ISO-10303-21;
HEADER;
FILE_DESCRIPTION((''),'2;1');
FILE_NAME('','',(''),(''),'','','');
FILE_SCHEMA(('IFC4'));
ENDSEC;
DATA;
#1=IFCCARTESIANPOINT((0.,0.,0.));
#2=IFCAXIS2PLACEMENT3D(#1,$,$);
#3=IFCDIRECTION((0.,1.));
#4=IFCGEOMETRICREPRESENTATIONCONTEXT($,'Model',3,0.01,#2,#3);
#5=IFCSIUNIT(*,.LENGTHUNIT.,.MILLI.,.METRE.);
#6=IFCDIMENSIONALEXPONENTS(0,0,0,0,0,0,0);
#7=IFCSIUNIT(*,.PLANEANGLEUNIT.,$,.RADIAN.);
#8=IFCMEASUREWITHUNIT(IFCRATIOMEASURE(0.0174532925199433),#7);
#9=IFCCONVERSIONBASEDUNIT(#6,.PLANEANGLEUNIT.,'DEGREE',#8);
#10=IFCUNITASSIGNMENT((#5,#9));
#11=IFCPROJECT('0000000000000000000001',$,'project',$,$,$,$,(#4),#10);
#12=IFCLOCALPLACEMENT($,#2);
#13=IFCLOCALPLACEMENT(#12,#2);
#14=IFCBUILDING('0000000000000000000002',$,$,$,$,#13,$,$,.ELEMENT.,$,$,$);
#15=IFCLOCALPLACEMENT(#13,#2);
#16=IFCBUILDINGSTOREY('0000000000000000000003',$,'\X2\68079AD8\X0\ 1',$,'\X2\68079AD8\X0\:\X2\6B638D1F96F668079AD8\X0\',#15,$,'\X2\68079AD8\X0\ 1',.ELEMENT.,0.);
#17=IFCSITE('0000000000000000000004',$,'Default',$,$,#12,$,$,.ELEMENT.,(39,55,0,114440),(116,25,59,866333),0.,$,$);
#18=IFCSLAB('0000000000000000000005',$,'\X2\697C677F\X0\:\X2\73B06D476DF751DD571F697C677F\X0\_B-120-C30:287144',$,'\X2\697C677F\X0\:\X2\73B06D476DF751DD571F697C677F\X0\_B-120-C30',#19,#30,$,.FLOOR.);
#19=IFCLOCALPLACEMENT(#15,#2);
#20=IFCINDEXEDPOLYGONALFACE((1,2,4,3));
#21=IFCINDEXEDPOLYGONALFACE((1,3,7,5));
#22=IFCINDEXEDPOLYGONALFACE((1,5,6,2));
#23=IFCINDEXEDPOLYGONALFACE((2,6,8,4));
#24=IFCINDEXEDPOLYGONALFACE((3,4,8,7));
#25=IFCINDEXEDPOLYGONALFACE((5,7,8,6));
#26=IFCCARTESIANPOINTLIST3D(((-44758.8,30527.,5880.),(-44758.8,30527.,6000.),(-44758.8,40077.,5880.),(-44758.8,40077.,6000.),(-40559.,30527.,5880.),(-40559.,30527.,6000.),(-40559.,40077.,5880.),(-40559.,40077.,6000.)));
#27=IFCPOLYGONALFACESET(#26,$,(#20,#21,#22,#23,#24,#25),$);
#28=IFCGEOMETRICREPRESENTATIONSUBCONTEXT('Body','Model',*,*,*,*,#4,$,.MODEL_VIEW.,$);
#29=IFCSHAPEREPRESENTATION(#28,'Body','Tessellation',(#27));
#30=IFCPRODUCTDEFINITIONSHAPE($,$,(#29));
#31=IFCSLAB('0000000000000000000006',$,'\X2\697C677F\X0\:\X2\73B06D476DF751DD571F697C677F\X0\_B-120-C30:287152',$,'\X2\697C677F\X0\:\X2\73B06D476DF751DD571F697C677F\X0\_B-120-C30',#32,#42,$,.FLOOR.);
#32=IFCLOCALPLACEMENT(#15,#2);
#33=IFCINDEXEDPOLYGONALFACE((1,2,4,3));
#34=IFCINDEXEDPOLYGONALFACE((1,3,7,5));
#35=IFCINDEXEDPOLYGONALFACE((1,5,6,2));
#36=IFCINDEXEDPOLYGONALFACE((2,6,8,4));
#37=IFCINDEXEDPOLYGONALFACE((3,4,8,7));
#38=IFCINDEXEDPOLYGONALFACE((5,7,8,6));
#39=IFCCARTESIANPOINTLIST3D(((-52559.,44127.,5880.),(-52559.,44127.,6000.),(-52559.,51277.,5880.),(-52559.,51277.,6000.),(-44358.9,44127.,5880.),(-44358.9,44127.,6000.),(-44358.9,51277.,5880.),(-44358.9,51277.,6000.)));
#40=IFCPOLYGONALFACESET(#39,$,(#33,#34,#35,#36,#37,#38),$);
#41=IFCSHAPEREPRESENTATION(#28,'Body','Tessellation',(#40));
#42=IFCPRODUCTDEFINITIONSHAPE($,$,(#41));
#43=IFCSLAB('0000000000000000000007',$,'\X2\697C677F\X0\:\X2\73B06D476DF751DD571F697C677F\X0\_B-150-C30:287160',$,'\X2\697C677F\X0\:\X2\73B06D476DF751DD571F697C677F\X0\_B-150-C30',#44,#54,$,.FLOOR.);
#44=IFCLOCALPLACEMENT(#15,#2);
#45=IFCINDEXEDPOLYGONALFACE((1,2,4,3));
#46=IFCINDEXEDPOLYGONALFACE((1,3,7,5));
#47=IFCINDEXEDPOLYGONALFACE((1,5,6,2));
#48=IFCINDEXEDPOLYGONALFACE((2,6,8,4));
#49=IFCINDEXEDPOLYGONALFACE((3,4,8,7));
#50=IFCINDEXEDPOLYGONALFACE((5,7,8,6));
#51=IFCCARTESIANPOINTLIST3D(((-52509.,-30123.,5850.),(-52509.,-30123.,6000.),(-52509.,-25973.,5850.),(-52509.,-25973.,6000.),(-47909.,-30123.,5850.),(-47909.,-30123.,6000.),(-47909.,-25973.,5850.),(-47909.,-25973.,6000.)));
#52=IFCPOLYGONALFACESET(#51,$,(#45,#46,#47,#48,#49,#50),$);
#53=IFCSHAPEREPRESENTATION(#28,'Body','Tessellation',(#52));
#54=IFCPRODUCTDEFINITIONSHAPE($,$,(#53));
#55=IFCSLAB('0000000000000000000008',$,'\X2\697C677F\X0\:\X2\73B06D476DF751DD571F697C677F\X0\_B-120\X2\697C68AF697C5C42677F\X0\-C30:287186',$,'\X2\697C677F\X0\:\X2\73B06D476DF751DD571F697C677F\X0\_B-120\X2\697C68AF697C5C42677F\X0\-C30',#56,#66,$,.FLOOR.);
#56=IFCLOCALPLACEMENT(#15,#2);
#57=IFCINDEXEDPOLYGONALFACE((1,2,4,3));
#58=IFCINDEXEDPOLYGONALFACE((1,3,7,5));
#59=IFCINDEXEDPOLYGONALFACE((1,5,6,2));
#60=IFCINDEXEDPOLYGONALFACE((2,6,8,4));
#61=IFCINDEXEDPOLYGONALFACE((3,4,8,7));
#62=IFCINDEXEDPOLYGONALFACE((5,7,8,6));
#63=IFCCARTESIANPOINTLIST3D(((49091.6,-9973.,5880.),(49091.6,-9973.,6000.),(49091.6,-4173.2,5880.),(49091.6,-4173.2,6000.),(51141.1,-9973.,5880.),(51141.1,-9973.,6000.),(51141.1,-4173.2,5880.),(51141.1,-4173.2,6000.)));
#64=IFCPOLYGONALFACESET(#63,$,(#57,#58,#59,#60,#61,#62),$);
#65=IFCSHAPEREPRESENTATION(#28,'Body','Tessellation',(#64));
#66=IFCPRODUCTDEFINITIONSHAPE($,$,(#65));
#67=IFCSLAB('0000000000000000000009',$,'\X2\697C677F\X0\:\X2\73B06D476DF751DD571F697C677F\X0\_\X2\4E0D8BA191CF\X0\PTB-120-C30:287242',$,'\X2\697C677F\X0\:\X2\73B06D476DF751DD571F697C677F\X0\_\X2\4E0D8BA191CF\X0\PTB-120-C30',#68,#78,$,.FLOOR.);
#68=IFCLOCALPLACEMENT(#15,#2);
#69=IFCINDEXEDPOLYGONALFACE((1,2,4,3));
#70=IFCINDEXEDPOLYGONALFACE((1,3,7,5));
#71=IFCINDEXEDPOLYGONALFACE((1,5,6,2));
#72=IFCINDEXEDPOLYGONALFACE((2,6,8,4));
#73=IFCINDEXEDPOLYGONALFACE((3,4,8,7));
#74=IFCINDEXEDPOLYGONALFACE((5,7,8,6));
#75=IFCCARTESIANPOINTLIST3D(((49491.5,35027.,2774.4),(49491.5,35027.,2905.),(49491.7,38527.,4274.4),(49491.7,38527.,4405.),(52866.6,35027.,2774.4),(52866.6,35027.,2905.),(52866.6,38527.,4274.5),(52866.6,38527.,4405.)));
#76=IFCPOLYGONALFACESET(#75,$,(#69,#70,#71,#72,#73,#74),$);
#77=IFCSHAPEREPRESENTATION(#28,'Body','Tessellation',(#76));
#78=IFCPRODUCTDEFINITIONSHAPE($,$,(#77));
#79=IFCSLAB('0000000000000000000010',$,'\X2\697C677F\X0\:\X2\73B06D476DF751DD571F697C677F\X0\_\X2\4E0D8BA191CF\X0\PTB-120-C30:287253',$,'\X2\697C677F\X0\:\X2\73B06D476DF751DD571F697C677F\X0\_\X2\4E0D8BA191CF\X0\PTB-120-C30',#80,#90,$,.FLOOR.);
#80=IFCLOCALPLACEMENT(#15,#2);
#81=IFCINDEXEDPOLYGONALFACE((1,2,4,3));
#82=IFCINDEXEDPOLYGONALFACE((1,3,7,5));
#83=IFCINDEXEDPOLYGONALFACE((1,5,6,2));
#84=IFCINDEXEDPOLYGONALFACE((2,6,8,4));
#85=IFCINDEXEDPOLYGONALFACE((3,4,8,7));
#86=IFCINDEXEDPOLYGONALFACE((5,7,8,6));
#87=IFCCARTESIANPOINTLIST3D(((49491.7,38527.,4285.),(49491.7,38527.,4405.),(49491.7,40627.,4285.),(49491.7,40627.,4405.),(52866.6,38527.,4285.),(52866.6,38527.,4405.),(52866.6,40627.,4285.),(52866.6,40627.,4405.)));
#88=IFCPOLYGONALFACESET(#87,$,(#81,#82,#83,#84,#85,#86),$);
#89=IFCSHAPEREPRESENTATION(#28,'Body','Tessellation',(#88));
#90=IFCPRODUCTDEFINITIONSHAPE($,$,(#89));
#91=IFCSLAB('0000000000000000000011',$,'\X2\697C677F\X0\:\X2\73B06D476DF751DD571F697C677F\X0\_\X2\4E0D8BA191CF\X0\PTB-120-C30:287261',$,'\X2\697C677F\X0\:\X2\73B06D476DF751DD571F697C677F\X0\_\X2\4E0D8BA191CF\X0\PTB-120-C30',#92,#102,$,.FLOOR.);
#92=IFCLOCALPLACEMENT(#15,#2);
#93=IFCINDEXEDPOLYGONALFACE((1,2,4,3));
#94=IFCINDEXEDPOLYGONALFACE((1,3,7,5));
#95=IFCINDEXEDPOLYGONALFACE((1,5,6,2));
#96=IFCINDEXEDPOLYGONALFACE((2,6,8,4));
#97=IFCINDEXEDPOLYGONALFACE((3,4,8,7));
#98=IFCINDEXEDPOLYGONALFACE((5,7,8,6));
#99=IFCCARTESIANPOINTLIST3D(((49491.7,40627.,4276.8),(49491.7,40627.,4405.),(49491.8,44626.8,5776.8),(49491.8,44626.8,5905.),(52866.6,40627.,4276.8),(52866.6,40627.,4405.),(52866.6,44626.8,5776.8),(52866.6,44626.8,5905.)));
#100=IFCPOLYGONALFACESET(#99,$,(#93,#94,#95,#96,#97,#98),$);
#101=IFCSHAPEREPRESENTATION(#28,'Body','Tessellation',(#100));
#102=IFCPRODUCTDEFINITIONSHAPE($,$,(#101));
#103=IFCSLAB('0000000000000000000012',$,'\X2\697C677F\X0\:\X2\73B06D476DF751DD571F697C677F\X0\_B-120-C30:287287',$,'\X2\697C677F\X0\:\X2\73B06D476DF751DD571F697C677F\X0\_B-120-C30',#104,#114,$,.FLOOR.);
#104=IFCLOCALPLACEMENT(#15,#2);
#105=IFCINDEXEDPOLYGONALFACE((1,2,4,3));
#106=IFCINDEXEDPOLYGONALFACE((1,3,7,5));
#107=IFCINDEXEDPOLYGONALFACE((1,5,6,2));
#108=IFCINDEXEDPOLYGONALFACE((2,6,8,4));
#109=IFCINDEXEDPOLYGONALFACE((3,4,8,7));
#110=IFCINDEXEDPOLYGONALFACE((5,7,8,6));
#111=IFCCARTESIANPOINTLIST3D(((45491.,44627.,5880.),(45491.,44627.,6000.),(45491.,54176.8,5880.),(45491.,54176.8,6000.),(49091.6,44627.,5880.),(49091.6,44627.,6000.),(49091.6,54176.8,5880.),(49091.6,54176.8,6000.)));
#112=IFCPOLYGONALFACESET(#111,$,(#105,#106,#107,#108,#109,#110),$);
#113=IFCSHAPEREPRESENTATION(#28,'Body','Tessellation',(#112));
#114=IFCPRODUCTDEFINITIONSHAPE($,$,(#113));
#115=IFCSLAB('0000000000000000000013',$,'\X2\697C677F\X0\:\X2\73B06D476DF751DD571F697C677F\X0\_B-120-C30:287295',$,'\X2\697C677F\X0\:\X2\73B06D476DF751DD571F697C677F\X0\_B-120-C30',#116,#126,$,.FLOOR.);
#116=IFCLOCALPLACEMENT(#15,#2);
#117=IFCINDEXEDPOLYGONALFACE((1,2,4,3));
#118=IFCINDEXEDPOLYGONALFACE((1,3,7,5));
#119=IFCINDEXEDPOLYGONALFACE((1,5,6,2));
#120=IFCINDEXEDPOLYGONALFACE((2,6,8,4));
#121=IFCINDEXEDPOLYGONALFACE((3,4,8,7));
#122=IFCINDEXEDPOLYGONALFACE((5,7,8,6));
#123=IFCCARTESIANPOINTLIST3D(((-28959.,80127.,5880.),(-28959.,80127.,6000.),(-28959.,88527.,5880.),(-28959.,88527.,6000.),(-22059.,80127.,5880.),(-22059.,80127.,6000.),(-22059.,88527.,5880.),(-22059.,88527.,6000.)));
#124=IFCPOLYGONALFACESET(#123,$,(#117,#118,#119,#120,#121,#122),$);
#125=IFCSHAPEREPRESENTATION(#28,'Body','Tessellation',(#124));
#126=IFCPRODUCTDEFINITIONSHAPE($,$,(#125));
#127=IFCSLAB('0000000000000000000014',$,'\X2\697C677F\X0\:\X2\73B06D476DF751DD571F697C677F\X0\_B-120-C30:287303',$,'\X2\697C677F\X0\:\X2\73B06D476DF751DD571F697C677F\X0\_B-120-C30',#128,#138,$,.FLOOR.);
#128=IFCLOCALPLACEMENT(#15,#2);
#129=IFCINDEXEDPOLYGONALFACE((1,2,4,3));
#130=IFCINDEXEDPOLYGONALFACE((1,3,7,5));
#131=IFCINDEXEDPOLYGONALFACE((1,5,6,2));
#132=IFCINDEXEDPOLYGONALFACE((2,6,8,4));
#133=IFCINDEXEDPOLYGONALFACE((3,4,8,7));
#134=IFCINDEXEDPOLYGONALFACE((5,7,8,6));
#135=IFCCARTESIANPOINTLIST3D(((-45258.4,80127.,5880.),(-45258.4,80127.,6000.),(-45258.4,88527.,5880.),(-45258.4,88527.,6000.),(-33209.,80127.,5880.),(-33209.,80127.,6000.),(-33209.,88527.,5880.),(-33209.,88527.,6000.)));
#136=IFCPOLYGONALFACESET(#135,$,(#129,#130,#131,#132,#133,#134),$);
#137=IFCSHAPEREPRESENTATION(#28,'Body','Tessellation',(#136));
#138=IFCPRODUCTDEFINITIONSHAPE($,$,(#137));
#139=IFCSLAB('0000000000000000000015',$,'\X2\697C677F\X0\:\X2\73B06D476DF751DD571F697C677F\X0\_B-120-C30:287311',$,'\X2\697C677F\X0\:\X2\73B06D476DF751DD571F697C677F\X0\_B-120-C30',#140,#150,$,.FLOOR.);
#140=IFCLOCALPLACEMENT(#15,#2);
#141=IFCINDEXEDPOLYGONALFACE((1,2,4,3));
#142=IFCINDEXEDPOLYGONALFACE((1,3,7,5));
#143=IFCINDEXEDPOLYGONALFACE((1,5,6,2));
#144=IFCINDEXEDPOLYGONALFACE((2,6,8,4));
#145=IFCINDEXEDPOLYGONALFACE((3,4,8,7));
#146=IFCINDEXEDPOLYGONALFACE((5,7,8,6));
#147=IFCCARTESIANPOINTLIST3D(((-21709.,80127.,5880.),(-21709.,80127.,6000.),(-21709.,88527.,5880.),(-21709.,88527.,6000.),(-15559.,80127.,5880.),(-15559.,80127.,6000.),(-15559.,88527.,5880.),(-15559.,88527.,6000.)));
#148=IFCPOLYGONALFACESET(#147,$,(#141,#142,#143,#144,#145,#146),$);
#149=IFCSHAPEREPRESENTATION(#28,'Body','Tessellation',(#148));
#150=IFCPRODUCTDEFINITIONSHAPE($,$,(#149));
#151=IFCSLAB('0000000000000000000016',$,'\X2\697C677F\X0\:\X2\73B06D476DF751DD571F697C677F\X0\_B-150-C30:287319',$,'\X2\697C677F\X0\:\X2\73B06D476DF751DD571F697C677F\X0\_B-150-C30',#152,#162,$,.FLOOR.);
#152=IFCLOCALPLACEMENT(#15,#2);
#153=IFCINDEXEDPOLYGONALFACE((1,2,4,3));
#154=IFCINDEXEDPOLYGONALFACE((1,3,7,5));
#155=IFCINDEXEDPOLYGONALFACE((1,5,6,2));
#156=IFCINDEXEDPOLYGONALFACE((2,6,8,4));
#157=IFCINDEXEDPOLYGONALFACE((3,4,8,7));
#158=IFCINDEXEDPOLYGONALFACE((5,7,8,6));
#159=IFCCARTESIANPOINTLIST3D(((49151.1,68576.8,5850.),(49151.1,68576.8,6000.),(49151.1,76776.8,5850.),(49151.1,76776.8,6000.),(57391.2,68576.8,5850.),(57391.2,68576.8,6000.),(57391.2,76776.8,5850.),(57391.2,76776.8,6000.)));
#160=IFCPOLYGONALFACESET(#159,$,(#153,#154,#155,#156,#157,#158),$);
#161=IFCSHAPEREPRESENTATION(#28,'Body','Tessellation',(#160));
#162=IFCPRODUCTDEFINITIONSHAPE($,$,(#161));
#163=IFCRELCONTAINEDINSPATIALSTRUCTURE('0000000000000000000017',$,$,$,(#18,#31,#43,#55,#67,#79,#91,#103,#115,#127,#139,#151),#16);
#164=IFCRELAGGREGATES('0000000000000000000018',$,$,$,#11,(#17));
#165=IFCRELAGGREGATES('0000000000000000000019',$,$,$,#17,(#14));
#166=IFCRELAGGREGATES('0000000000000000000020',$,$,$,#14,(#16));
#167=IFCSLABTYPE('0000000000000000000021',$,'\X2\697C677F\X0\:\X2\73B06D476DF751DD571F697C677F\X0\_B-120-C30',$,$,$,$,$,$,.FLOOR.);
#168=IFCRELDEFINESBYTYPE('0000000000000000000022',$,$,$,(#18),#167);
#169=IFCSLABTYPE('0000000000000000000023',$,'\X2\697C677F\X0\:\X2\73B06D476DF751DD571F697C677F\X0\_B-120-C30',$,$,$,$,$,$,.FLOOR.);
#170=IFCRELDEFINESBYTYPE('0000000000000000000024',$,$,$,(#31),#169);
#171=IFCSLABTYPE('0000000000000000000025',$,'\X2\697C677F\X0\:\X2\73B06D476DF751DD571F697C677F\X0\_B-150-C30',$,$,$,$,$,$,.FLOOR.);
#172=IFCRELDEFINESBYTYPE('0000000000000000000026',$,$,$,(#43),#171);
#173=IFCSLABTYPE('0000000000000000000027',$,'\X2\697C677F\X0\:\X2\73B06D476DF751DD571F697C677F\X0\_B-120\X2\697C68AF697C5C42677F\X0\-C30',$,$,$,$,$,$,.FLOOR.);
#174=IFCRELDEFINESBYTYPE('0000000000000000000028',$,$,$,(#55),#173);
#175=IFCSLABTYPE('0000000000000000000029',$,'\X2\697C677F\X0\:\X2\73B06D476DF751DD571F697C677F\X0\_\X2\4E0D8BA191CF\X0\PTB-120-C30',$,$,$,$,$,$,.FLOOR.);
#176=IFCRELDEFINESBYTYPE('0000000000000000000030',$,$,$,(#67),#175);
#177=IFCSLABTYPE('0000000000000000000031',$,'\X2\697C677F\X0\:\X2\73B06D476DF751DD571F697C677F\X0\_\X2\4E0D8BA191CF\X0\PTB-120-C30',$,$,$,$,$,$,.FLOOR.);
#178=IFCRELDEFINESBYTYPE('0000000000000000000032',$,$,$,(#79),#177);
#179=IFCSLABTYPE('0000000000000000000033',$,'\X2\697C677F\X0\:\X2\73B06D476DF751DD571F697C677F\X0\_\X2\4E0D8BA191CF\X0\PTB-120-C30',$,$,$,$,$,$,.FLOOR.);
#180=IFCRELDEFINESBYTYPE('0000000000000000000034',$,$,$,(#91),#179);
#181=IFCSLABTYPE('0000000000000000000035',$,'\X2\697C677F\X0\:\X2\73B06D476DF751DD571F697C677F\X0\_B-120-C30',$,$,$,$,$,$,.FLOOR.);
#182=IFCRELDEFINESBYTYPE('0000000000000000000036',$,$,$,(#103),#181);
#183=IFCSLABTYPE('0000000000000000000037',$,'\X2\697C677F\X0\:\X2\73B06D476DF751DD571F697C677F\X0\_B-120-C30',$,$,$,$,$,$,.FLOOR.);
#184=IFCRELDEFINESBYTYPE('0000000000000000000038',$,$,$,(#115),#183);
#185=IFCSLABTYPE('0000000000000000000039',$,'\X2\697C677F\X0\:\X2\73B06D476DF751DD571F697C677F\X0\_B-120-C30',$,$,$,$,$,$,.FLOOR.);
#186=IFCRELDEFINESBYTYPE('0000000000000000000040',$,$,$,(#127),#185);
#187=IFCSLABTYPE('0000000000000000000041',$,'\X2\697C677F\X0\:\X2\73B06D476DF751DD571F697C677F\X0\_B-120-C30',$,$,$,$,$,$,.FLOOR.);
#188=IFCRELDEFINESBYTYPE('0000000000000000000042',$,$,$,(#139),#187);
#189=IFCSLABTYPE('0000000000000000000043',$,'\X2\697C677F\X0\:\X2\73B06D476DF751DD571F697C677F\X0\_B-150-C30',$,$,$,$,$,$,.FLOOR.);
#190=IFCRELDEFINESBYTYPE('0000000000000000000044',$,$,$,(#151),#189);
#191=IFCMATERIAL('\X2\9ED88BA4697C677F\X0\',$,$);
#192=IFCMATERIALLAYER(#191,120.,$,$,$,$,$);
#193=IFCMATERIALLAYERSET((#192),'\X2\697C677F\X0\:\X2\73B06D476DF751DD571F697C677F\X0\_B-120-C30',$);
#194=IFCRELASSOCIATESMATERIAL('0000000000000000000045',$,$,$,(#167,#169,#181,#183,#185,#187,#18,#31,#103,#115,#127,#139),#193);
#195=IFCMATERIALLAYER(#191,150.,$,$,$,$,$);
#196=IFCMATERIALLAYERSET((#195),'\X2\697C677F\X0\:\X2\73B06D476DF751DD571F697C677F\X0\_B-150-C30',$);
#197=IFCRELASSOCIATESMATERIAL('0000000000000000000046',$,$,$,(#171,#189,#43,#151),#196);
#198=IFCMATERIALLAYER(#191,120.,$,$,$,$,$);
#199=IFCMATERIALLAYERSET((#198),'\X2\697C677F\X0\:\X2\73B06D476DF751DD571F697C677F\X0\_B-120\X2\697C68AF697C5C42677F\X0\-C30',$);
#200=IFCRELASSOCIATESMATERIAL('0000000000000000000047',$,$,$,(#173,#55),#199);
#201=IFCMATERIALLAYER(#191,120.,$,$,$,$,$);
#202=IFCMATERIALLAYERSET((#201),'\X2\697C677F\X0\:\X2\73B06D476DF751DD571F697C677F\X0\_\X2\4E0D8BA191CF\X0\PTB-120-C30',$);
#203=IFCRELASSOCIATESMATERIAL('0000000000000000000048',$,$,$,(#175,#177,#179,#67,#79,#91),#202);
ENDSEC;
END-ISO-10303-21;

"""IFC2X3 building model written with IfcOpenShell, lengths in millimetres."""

from ifc_helpers import new_model, entity, si_unit, converted_unit, direction, frame, frame_2d, origin, place, context, subcontext, project, spatial, polyline, rectangle, outline, extrude, clip, halfspace, material, layer, layer_set, layer_usage, type_object, element, save


model = new_model("IFC2X3")

# Units and contexts
model_context = context("Model", 3, precision=0.01, world=origin(), true_north=direction((0.0, 1.0)))
body_context = subcontext(model_context, "Body", "Model", "MODEL_VIEW")
ifc_project = project(units=[si_unit("LENGTHUNIT", "METRE", prefix="MILLI"), converted_unit("PLANEANGLEUNIT", "DEGREE", entity("IfcRatioMeasure", 0.0174532925199433), si_unit("PLANEANGLEUNIT", "RADIAN"), dimensions=[0, 0, 0, 0, 0, 0, 0])], contexts=[model_context])

# Site, building, storey
site_placement = place(None, origin())
site = spatial("IfcSite", under=ifc_project, at=site_placement, Name="Default", CompositionType="ELEMENT", RefLatitude=(39, 55, 0, 114440), RefLongitude=(116, 25, 59, 866333), RefElevation=0.0)
building_placement = place(site_placement, origin())
building = spatial("IfcBuilding", under=site, at=building_placement, CompositionType="ELEMENT")
storey_placement = place(building_placement, origin())
storey = spatial("IfcBuildingStorey", under=building, at=storey_placement, Name="标高 1", ObjectType="标高:正负零标高", LongName="标高 1", CompositionType="ELEMENT", Elevation=0.0)

# Slabs
ifc_material = material(Name="默认楼板")
ifc_layer_1 = layer(ifc_material, 120.0)
ifc_layer_set_1 = layer_set([ifc_layer_1], Name="楼板:现浇混凝土楼板_B-120-C30")
ifc_layer_usage_1 = layer_usage(ifc_layer_set_1, "AXIS3", "POSITIVE", 0.0)
slab_type_1 = type_object("IfcSlabType", Name="楼板:现浇混凝土楼板_B-120-C30", PredefinedType="FLOOR", material=ifc_layer_set_1)
slab_1_placement = place(building_placement, origin())
element("IfcSlab", 1, at=slab_1_placement, inside=storey, type_object=slab_type_1, material=ifc_layer_usage_1, Name="楼板:现浇混凝土楼板_B-120-C30:287144", ObjectType="楼板:现浇混凝土楼板_B-120-C30", PredefinedType="FLOOR", context=body_context, shape_type="SweptSolid", body=[
    extrude(outline(polyline([(-4775.0, -2099.9), (4775.0, -2099.9), (4775.0, 2099.9), (-4775.0, 2099.9), (-4775.0, -2099.9)])), frame((-42658.9, 35302.0, 6000.0), z_axis=(0.0, 0.0, -1.0), x_axis=(0.0, 1.0, 0.0)), (0.0, 0.0, 1.0), 120.0),
])
ifc_layer_usage_2 = layer_usage(ifc_layer_set_1, "AXIS3", "POSITIVE", 0.0)
slab_type_2 = type_object("IfcSlabType", Name="楼板:现浇混凝土楼板_B-120-C30", PredefinedType="FLOOR", material=ifc_layer_set_1)
slab_2_placement = place(building_placement, origin())
element("IfcSlab", 2, at=slab_2_placement, inside=storey, type_object=slab_type_2, material=ifc_layer_usage_2, Name="楼板:现浇混凝土楼板_B-120-C30:287152", ObjectType="楼板:现浇混凝土楼板_B-120-C30", PredefinedType="FLOOR", context=body_context, shape_type="SweptSolid", body=[
    extrude(rectangle(XDim=7150.0, YDim=8200.1, at=frame_2d((0.0, 0.0), x_axis=(1.0, 0.0))), frame((-48458.9, 47702.0, 6000.0), z_axis=(0.0, 0.0, -1.0), x_axis=(0.0, 1.0, 0.0)), (0.0, 0.0, 1.0), 120.0),
])
ifc_layer_2 = layer(ifc_material, 150.0)
ifc_layer_set_2 = layer_set([ifc_layer_2], Name="楼板:现浇混凝土楼板_B-150-C30")
ifc_layer_usage_3 = layer_usage(ifc_layer_set_2, "AXIS3", "POSITIVE", 0.0)
slab_type_3 = type_object("IfcSlabType", Name="楼板:现浇混凝土楼板_B-150-C30", PredefinedType="FLOOR", material=ifc_layer_set_2)
slab_3_placement = place(building_placement, origin())
element("IfcSlab", 3, at=slab_3_placement, inside=storey, type_object=slab_type_3, material=ifc_layer_usage_3, Name="楼板:现浇混凝土楼板_B-150-C30:287160", ObjectType="楼板:现浇混凝土楼板_B-150-C30", PredefinedType="FLOOR", context=body_context, shape_type="SweptSolid", body=[
    extrude(outline(polyline([(-2075.0, -2300.0), (2075.0, -2300.0), (2075.0, 2300.0), (-2075.0, 2300.0), (-2075.0, -2300.0)])), frame((-50209.0, -28048.0, 6000.0), z_axis=(0.0, 0.0, -1.0), x_axis=(0.0, 1.0, 0.0)), (0.0, 0.0, 1.0), 150.0),
])
ifc_layer_3 = layer(ifc_material, 120.0)
ifc_layer_set_3 = layer_set([ifc_layer_3], Name="楼板:现浇混凝土楼板_B-120楼梯楼层板-C30")
ifc_layer_usage_4 = layer_usage(ifc_layer_set_3, "AXIS3", "POSITIVE", 0.0)
slab_type_4 = type_object("IfcSlabType", Name="楼板:现浇混凝土楼板_B-120楼梯楼层板-C30", PredefinedType="FLOOR", material=ifc_layer_set_3)
slab_4_placement = place(building_placement, origin())
element("IfcSlab", 4, at=slab_4_placement, inside=storey, type_object=slab_type_4, material=ifc_layer_usage_4, Name="楼板:现浇混凝土楼板_B-120楼梯楼层板-C30:287186", ObjectType="楼板:现浇混凝土楼板_B-120楼梯楼层板-C30", PredefinedType="FLOOR", context=body_context, shape_type="SweptSolid", body=[
    extrude(outline(polyline([(-2899.9, -1024.7), (2899.9, -1024.7), (2899.9, 1024.7), (-2899.9, 1024.7), (-2899.9, -1024.7)])), frame((50116.4, -7073.1, 6000.0), z_axis=(0.0, 0.0, -1.0), x_axis=(0.0, 1.0, 0.0)), (0.0, 0.0, 1.0), 120.0),
])
ifc_layer_4 = layer(ifc_material, 120.0)
ifc_layer_set_4 = layer_set([ifc_layer_4], Name="楼板:现浇混凝土楼板_不计量PTB-120-C30")
ifc_layer_usage_5 = layer_usage(ifc_layer_set_4, "AXIS3", "POSITIVE", 0.0)
slab_type_5 = type_object("IfcSlabType", Name="楼板:现浇混凝土楼板_不计量PTB-120-C30", PredefinedType="FLOOR", material=ifc_layer_set_4)
slab_5_placement = place(building_placement, origin())
element("IfcSlab", 5, at=slab_5_placement, inside=storey, type_object=slab_type_5, material=ifc_layer_usage_5, Name="楼板:现浇混凝土楼板_不计量PTB-120-C30:287242", ObjectType="楼板:现浇混凝土楼板_不计量PTB-120-C30", PredefinedType="FLOOR", context=body_context, shape_type="Clipping", body=[
    clip(clip(extrude(outline(polyline([(-1904.0, -1687.5), (1903.9, -1687.5), (1903.9, 1687.6), (-1903.9, 1687.5), (-1904.0, -1687.5)])), frame((51179.1, 36777.0, 3655.0), z_axis=(0.000001, 0.393924, -0.919143), x_axis=(0.0, -0.919143, -0.393924)), (0.393924, 0.000001, 0.919143), 142.0), halfspace(frame((52866.6, 35027.0, 2774.4), z_axis=(0.000001, 0.393924, -0.919143), x_axis=(0.000001, 0.919143, 0.393924)), False)), halfspace(frame((52866.6, 35027.0, 2905.0), z_axis=(-0.000001, -0.393924, 0.919143), x_axis=(-0.000001, -0.919143, -0.393924)), False)),
])
ifc_layer_usage_6 = layer_usage(ifc_layer_set_4, "AXIS3", "POSITIVE", 0.0)
slab_type_6 = type_object("IfcSlabType", Name="楼板:现浇混凝土楼板_不计量PTB-120-C30", PredefinedType="FLOOR", material=ifc_layer_set_4)
slab_6_placement = place(building_placement, origin())
element("IfcSlab", 6, at=slab_6_placement, inside=storey, type_object=slab_type_6, material=ifc_layer_usage_6, Name="楼板:现浇混凝土楼板_不计量PTB-120-C30:287253", ObjectType="楼板:现浇混凝土楼板_不计量PTB-120-C30", PredefinedType="FLOOR", context=body_context, shape_type="SweptSolid", body=[
    extrude(outline(polyline([(-1050.0, -1687.5), (1050.0, -1687.5), (1050.0, 1687.5), (-1050.0, 1687.4), (-1050.0, -1687.5)])), frame((51179.2, 39577.0, 4405.0), z_axis=(0.0, 0.0, -1.0), x_axis=(0.0, -1.0, 0.0)), (0.0, 0.0, 1.0), 120.0),
])
ifc_layer_usage_7 = layer_usage(ifc_layer_set_4, "AXIS3", "POSITIVE", 0.0)
slab_type_7 = type_object("IfcSlabType", Name="楼板:现浇混凝土楼板_不计量PTB-120-C30", PredefinedType="FLOOR", material=ifc_layer_set_4)
slab_7_placement = place(building_placement, origin())
element("IfcSlab", 7, at=slab_7_placement, inside=storey, type_object=slab_type_7, material=ifc_layer_usage_7, Name="楼板:现浇混凝土楼板_不计量PTB-120-C30:287261", ObjectType="楼板:现浇混凝土楼板_不计量PTB-120-C30", PredefinedType="FLOOR", context=body_context, shape_type="Clipping", body=[
    clip(clip(extrude(outline(polyline([(-2135.9, -1687.4), (2135.9, -1687.4), (2135.9, 1687.5), (-2135.9, 1687.4), (-2135.9, -1687.4)])), frame((51179.2, 42626.9, 5155.0), z_axis=(-0.000005, 0.351134, -0.936325), x_axis=(0.0, -0.936325, -0.351134)), (0.351134, -0.000004, 0.936325), 136.9), halfspace(frame((52866.6, 40627.0, 4276.8), z_axis=(-0.000005, 0.351134, -0.936325), x_axis=(-0.000012, 0.936325, 0.351134)), False)), halfspace(frame((52866.6, 40627.0, 4405.0), z_axis=(0.000005, -0.351134, 0.936325), x_axis=(0.000012, -0.936325, -0.351134)), False)),
])
ifc_layer_usage_8 = layer_usage(ifc_layer_set_1, "AXIS3", "POSITIVE", 0.0)
slab_type_8 = type_object("IfcSlabType", Name="楼板:现浇混凝土楼板_B-120-C30", PredefinedType="FLOOR", material=ifc_layer_set_1)
slab_8_placement = place(building_placement, origin())
element("IfcSlab", 8, at=slab_8_placement, inside=storey, type_object=slab_type_8, material=ifc_layer_usage_8, Name="楼板:现浇混凝土楼板_B-120-C30:287287", ObjectType="楼板:现浇混凝土楼板_B-120-C30", PredefinedType="FLOOR", context=body_context, shape_type="SweptSolid", body=[
    extrude(rectangle(XDim=9549.8, YDim=3600.6, at=frame_2d((0.0, 0.0), x_axis=(1.0, 0.0))), frame((47291.3, 49401.9, 6000.0), z_axis=(0.0, 0.0, -1.0), x_axis=(0.0, 1.0, 0.0)), (0.0, 0.0, 1.0), 120.0),
])
ifc_layer_usage_9 = layer_usage(ifc_layer_set_1, "AXIS3", "POSITIVE", 0.0)
slab_type_9 = type_object("IfcSlabType", Name="楼板:现浇混凝土楼板_B-120-C30", PredefinedType="FLOOR", material=ifc_layer_set_1)
slab_9_placement = place(building_placement, origin())
element("IfcSlab", 9, at=slab_9_placement, inside=storey, type_object=slab_type_9, material=ifc_layer_usage_9, Name="楼板:现浇混凝土楼板_B-120-C30:287295", ObjectType="楼板:现浇混凝土楼板_B-120-C30", PredefinedType="FLOOR", context=body_context, shape_type="SweptSolid", body=[
    extrude(rectangle(XDim=8400.0, YDim=6900.0, at=frame_2d((0.0, 0.0), x_axis=(1.0, 0.0))), frame((-25509.0, 84327.0, 6000.0), z_axis=(0.0, 0.0, -1.0), x_axis=(0.0, 1.0, 0.0)), (0.0, 0.0, 1.0), 120.0),
])
ifc_layer_usage_10 = layer_usage(ifc_layer_set_1, "AXIS3", "POSITIVE", 0.0)
slab_type_10 = type_object("IfcSlabType", Name="楼板:现浇混凝土楼板_B-120-C30", PredefinedType="FLOOR", material=ifc_layer_set_1)
slab_10_placement = place(building_placement, origin())
element("IfcSlab", 10, at=slab_10_placement, inside=storey, type_object=slab_type_10, material=ifc_layer_usage_10, Name="楼板:现浇混凝土楼板_B-120-C30:287303", ObjectType="楼板:现浇混凝土楼板_B-120-C30", PredefinedType="FLOOR", context=body_context, shape_type="SweptSolid", body=[
    extrude(rectangle(XDim=8400.0, YDim=12049.4, at=frame_2d((0.0, 0.0), x_axis=(1.0, 0.0))), frame((-39233.7, 84327.0, 6000.0), z_axis=(0.0, 0.0, -1.0), x_axis=(0.0, 1.0, 0.0)), (0.0, 0.0, 1.0), 120.0),
])
ifc_layer_usage_11 = layer_usage(ifc_layer_set_1, "AXIS3", "POSITIVE", 0.0)
slab_type_11 = type_object("IfcSlabType", Name="楼板:现浇混凝土楼板_B-120-C30", PredefinedType="FLOOR", material=ifc_layer_set_1)
slab_11_placement = place(building_placement, origin())
element("IfcSlab", 11, at=slab_11_placement, inside=storey, type_object=slab_type_11, material=ifc_layer_usage_11, Name="楼板:现浇混凝土楼板_B-120-C30:287311", ObjectType="楼板:现浇混凝土楼板_B-120-C30", PredefinedType="FLOOR", context=body_context, shape_type="SweptSolid", body=[
    extrude(rectangle(XDim=8400.0, YDim=6150.0, at=frame_2d((0.0, 0.0), x_axis=(1.0, 0.0))), frame((-18634.0, 84327.0, 6000.0), z_axis=(0.0, 0.0, -1.0), x_axis=(0.0, 1.0, 0.0)), (0.0, 0.0, 1.0), 120.0),
])
ifc_layer_usage_12 = layer_usage(ifc_layer_set_2, "AXIS3", "POSITIVE", 0.0)
slab_type_12 = type_object("IfcSlabType", Name="楼板:现浇混凝土楼板_B-150-C30", PredefinedType="FLOOR", material=ifc_layer_set_2)
slab_12_placement = place(building_placement, origin())
element("IfcSlab", 12, at=slab_12_placement, inside=storey, type_object=slab_type_12, material=ifc_layer_usage_12, Name="楼板:现浇混凝土楼板_B-150-C30:287319", ObjectType="楼板:现浇混凝土楼板_B-150-C30", PredefinedType="FLOOR", context=body_context, shape_type="SweptSolid", body=[
    extrude(rectangle(XDim=8200.0, YDim=8240.1, at=frame_2d((0.0, 0.0), x_axis=(1.0, 0.0))), frame((53271.2, 72676.8, 6000.0), z_axis=(0.0, 0.0, -1.0), x_axis=(0.0, 1.0, 0.0)), (0.0, 0.0, 1.0), 150.0),
])

save(model, "model.ifc")
